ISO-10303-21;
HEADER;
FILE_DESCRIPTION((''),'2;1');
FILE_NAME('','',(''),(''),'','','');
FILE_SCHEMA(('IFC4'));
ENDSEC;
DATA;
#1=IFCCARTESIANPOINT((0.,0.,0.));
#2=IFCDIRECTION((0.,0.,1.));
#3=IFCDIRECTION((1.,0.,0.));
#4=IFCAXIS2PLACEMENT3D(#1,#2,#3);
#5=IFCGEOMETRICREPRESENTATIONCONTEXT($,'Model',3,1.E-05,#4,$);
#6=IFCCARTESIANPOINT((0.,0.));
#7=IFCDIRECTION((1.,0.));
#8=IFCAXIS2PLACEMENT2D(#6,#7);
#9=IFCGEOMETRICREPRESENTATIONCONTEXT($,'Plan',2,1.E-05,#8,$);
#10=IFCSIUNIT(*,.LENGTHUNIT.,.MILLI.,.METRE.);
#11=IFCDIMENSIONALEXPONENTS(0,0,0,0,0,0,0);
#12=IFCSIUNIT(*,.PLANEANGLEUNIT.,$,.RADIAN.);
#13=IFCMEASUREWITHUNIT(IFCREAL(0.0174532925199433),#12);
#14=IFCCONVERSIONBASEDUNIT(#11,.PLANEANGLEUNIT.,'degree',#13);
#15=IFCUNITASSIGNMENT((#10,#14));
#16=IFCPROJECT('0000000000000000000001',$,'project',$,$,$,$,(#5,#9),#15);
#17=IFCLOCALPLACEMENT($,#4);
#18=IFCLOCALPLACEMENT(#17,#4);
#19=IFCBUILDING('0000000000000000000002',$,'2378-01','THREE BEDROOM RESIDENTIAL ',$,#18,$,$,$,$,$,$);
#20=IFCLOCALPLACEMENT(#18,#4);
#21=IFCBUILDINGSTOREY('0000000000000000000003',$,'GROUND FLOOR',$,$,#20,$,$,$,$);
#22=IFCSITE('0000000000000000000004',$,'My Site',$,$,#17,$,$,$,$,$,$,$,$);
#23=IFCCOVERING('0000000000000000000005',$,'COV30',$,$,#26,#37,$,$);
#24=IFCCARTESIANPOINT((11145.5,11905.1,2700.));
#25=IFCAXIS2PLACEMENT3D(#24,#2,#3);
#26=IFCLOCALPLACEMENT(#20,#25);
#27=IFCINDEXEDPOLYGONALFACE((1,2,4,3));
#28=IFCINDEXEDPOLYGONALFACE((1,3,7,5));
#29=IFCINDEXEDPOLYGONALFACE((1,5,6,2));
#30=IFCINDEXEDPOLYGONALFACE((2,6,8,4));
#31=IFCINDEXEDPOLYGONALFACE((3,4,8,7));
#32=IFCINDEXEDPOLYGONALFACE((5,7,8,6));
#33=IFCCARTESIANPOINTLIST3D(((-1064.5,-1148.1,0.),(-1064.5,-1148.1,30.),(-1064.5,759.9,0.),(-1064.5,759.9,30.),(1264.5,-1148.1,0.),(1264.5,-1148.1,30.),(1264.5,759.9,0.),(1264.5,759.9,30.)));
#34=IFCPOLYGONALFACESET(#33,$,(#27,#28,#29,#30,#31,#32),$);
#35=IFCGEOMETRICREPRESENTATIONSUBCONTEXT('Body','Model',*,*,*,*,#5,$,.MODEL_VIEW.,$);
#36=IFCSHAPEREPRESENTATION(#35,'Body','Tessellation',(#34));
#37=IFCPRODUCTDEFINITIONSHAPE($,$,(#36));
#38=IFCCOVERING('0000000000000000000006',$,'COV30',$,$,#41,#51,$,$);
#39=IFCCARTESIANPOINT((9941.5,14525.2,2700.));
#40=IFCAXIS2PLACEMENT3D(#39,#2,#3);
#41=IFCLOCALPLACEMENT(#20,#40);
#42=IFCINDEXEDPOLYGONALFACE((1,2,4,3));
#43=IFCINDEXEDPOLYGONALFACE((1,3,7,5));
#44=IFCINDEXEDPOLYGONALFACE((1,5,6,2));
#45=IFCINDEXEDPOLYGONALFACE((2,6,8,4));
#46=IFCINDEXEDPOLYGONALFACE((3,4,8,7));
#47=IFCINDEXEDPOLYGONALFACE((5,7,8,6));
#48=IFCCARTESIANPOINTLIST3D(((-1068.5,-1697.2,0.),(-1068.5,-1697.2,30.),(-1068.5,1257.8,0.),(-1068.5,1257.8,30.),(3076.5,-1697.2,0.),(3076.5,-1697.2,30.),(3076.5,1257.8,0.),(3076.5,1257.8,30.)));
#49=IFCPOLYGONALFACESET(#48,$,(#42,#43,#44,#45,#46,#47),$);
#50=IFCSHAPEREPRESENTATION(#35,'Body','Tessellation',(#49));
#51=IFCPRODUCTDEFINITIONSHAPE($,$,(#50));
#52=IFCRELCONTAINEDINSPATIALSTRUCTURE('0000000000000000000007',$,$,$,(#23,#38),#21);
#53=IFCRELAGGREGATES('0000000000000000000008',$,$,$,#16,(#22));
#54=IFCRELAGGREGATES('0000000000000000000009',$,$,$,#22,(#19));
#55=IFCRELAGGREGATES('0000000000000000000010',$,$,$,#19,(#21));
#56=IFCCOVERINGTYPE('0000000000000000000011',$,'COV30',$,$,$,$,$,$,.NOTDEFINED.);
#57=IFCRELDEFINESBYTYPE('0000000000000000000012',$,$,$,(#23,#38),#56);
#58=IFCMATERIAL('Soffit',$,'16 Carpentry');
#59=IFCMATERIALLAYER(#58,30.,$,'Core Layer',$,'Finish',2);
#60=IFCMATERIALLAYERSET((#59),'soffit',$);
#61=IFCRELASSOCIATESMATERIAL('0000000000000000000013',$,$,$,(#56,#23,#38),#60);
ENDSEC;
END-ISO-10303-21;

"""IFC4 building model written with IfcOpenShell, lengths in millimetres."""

from ifc_helpers import new_model, entity, si_unit, converted_unit, frame, origin_with_axes, origin_2d_with_axis, place, context, subcontext, project, spatial, line, indexed_curve, outline, extrude, material, layer, layer_set, layer_usage, type_object, element, save


model = new_model("IFC4")

# Units and contexts
model_context = context("Model", 3, precision=1e-05, world=origin_with_axes())
plan_context = context("Plan", 2, precision=1e-05, world=origin_2d_with_axis())
body_context_1 = subcontext(model_context, "Body", "Model", "MODEL_VIEW")
ifc_project = project(units=[si_unit("LENGTHUNIT", "METRE", prefix="MILLI"), converted_unit("PLANEANGLEUNIT", "degree", entity("IfcReal", 0.0174532925199433), si_unit("PLANEANGLEUNIT", "RADIAN"), dimensions=[0, 0, 0, 0, 0, 0, 0])], contexts=[model_context, plan_context])

# Site, building, storey
site_placement = place(None, origin_with_axes())
site = spatial("IfcSite", under=ifc_project, at=site_placement, Name="My Site")
building_placement = place(site_placement, origin_with_axes())
building = spatial("IfcBuilding", under=site, at=building_placement, Name="2378-01", Description="THREE BEDROOM RESIDENTIAL ")
storey_placement = place(building_placement, origin_with_axes())
storey = spatial("IfcBuildingStorey", under=building, at=storey_placement, Name="GROUND FLOOR")

# Coverings
ifc_material_1 = material(Name="Soffit", Category="16 Carpentry")
ifc_layer_1 = layer(ifc_material_1, 30.0, Name="Core Layer", Category="Finish", Priority=2)
ifc_layer_set_1 = layer_set([ifc_layer_1], Name="soffit")
ifc_layer_usage_1 = layer_usage(ifc_layer_set_1, "AXIS3", "POSITIVE", 0.0)
covering_type = type_object("IfcCoveringType", Name="COV30", PredefinedType="NOTDEFINED", material=ifc_layer_set_1)
covering_1_placement = place(storey_placement, frame((11145.5, 11905.1, 2700.0), z_axis=(0.0, 0.0, 1.0), x_axis=(1.0, 0.0, 0.0)))
element("IfcCovering", 1, at=covering_1_placement, inside=storey, type_object=covering_type, material=ifc_layer_usage_1, Name="COV30", context=body_context_1, shape_type="SweptSolid", body=[
    extrude(outline(indexed_curve([(1264.5, -1148.1), (-1064.5, -1148.1), (-1064.5, 759.9), (1264.5, 759.9), (1264.5, -1148.1)], segments=[line(1, 2, 3, 4, 5, 1)])), None, (0.0, 0.0, 1.0), 30.0),
])
ifc_layer_usage_2 = layer_usage(ifc_layer_set_1, "AXIS3", "POSITIVE", 0.0)
covering_2_placement = place(storey_placement, frame((9941.5, 14525.2, 2700.0), z_axis=(0.0, 0.0, 1.0), x_axis=(1.0, 0.0, 0.0)))
element("IfcCovering", 2, at=covering_2_placement, inside=storey, type_object=covering_type, material=ifc_layer_usage_2, Name="COV30", context=body_context_1, shape_type="SweptSolid", body=[
    extrude(outline(indexed_curve([(-1068.5, -1697.2), (-1068.5, 1257.8), (3076.5, 1257.8), (3076.5, -1697.2), (-1068.5, -1697.2)], segments=[line(1, 2, 3, 4, 5, 1)])), None, (0.0, 0.0, 1.0), 30.0),
])

save(model, "model.ifc")
